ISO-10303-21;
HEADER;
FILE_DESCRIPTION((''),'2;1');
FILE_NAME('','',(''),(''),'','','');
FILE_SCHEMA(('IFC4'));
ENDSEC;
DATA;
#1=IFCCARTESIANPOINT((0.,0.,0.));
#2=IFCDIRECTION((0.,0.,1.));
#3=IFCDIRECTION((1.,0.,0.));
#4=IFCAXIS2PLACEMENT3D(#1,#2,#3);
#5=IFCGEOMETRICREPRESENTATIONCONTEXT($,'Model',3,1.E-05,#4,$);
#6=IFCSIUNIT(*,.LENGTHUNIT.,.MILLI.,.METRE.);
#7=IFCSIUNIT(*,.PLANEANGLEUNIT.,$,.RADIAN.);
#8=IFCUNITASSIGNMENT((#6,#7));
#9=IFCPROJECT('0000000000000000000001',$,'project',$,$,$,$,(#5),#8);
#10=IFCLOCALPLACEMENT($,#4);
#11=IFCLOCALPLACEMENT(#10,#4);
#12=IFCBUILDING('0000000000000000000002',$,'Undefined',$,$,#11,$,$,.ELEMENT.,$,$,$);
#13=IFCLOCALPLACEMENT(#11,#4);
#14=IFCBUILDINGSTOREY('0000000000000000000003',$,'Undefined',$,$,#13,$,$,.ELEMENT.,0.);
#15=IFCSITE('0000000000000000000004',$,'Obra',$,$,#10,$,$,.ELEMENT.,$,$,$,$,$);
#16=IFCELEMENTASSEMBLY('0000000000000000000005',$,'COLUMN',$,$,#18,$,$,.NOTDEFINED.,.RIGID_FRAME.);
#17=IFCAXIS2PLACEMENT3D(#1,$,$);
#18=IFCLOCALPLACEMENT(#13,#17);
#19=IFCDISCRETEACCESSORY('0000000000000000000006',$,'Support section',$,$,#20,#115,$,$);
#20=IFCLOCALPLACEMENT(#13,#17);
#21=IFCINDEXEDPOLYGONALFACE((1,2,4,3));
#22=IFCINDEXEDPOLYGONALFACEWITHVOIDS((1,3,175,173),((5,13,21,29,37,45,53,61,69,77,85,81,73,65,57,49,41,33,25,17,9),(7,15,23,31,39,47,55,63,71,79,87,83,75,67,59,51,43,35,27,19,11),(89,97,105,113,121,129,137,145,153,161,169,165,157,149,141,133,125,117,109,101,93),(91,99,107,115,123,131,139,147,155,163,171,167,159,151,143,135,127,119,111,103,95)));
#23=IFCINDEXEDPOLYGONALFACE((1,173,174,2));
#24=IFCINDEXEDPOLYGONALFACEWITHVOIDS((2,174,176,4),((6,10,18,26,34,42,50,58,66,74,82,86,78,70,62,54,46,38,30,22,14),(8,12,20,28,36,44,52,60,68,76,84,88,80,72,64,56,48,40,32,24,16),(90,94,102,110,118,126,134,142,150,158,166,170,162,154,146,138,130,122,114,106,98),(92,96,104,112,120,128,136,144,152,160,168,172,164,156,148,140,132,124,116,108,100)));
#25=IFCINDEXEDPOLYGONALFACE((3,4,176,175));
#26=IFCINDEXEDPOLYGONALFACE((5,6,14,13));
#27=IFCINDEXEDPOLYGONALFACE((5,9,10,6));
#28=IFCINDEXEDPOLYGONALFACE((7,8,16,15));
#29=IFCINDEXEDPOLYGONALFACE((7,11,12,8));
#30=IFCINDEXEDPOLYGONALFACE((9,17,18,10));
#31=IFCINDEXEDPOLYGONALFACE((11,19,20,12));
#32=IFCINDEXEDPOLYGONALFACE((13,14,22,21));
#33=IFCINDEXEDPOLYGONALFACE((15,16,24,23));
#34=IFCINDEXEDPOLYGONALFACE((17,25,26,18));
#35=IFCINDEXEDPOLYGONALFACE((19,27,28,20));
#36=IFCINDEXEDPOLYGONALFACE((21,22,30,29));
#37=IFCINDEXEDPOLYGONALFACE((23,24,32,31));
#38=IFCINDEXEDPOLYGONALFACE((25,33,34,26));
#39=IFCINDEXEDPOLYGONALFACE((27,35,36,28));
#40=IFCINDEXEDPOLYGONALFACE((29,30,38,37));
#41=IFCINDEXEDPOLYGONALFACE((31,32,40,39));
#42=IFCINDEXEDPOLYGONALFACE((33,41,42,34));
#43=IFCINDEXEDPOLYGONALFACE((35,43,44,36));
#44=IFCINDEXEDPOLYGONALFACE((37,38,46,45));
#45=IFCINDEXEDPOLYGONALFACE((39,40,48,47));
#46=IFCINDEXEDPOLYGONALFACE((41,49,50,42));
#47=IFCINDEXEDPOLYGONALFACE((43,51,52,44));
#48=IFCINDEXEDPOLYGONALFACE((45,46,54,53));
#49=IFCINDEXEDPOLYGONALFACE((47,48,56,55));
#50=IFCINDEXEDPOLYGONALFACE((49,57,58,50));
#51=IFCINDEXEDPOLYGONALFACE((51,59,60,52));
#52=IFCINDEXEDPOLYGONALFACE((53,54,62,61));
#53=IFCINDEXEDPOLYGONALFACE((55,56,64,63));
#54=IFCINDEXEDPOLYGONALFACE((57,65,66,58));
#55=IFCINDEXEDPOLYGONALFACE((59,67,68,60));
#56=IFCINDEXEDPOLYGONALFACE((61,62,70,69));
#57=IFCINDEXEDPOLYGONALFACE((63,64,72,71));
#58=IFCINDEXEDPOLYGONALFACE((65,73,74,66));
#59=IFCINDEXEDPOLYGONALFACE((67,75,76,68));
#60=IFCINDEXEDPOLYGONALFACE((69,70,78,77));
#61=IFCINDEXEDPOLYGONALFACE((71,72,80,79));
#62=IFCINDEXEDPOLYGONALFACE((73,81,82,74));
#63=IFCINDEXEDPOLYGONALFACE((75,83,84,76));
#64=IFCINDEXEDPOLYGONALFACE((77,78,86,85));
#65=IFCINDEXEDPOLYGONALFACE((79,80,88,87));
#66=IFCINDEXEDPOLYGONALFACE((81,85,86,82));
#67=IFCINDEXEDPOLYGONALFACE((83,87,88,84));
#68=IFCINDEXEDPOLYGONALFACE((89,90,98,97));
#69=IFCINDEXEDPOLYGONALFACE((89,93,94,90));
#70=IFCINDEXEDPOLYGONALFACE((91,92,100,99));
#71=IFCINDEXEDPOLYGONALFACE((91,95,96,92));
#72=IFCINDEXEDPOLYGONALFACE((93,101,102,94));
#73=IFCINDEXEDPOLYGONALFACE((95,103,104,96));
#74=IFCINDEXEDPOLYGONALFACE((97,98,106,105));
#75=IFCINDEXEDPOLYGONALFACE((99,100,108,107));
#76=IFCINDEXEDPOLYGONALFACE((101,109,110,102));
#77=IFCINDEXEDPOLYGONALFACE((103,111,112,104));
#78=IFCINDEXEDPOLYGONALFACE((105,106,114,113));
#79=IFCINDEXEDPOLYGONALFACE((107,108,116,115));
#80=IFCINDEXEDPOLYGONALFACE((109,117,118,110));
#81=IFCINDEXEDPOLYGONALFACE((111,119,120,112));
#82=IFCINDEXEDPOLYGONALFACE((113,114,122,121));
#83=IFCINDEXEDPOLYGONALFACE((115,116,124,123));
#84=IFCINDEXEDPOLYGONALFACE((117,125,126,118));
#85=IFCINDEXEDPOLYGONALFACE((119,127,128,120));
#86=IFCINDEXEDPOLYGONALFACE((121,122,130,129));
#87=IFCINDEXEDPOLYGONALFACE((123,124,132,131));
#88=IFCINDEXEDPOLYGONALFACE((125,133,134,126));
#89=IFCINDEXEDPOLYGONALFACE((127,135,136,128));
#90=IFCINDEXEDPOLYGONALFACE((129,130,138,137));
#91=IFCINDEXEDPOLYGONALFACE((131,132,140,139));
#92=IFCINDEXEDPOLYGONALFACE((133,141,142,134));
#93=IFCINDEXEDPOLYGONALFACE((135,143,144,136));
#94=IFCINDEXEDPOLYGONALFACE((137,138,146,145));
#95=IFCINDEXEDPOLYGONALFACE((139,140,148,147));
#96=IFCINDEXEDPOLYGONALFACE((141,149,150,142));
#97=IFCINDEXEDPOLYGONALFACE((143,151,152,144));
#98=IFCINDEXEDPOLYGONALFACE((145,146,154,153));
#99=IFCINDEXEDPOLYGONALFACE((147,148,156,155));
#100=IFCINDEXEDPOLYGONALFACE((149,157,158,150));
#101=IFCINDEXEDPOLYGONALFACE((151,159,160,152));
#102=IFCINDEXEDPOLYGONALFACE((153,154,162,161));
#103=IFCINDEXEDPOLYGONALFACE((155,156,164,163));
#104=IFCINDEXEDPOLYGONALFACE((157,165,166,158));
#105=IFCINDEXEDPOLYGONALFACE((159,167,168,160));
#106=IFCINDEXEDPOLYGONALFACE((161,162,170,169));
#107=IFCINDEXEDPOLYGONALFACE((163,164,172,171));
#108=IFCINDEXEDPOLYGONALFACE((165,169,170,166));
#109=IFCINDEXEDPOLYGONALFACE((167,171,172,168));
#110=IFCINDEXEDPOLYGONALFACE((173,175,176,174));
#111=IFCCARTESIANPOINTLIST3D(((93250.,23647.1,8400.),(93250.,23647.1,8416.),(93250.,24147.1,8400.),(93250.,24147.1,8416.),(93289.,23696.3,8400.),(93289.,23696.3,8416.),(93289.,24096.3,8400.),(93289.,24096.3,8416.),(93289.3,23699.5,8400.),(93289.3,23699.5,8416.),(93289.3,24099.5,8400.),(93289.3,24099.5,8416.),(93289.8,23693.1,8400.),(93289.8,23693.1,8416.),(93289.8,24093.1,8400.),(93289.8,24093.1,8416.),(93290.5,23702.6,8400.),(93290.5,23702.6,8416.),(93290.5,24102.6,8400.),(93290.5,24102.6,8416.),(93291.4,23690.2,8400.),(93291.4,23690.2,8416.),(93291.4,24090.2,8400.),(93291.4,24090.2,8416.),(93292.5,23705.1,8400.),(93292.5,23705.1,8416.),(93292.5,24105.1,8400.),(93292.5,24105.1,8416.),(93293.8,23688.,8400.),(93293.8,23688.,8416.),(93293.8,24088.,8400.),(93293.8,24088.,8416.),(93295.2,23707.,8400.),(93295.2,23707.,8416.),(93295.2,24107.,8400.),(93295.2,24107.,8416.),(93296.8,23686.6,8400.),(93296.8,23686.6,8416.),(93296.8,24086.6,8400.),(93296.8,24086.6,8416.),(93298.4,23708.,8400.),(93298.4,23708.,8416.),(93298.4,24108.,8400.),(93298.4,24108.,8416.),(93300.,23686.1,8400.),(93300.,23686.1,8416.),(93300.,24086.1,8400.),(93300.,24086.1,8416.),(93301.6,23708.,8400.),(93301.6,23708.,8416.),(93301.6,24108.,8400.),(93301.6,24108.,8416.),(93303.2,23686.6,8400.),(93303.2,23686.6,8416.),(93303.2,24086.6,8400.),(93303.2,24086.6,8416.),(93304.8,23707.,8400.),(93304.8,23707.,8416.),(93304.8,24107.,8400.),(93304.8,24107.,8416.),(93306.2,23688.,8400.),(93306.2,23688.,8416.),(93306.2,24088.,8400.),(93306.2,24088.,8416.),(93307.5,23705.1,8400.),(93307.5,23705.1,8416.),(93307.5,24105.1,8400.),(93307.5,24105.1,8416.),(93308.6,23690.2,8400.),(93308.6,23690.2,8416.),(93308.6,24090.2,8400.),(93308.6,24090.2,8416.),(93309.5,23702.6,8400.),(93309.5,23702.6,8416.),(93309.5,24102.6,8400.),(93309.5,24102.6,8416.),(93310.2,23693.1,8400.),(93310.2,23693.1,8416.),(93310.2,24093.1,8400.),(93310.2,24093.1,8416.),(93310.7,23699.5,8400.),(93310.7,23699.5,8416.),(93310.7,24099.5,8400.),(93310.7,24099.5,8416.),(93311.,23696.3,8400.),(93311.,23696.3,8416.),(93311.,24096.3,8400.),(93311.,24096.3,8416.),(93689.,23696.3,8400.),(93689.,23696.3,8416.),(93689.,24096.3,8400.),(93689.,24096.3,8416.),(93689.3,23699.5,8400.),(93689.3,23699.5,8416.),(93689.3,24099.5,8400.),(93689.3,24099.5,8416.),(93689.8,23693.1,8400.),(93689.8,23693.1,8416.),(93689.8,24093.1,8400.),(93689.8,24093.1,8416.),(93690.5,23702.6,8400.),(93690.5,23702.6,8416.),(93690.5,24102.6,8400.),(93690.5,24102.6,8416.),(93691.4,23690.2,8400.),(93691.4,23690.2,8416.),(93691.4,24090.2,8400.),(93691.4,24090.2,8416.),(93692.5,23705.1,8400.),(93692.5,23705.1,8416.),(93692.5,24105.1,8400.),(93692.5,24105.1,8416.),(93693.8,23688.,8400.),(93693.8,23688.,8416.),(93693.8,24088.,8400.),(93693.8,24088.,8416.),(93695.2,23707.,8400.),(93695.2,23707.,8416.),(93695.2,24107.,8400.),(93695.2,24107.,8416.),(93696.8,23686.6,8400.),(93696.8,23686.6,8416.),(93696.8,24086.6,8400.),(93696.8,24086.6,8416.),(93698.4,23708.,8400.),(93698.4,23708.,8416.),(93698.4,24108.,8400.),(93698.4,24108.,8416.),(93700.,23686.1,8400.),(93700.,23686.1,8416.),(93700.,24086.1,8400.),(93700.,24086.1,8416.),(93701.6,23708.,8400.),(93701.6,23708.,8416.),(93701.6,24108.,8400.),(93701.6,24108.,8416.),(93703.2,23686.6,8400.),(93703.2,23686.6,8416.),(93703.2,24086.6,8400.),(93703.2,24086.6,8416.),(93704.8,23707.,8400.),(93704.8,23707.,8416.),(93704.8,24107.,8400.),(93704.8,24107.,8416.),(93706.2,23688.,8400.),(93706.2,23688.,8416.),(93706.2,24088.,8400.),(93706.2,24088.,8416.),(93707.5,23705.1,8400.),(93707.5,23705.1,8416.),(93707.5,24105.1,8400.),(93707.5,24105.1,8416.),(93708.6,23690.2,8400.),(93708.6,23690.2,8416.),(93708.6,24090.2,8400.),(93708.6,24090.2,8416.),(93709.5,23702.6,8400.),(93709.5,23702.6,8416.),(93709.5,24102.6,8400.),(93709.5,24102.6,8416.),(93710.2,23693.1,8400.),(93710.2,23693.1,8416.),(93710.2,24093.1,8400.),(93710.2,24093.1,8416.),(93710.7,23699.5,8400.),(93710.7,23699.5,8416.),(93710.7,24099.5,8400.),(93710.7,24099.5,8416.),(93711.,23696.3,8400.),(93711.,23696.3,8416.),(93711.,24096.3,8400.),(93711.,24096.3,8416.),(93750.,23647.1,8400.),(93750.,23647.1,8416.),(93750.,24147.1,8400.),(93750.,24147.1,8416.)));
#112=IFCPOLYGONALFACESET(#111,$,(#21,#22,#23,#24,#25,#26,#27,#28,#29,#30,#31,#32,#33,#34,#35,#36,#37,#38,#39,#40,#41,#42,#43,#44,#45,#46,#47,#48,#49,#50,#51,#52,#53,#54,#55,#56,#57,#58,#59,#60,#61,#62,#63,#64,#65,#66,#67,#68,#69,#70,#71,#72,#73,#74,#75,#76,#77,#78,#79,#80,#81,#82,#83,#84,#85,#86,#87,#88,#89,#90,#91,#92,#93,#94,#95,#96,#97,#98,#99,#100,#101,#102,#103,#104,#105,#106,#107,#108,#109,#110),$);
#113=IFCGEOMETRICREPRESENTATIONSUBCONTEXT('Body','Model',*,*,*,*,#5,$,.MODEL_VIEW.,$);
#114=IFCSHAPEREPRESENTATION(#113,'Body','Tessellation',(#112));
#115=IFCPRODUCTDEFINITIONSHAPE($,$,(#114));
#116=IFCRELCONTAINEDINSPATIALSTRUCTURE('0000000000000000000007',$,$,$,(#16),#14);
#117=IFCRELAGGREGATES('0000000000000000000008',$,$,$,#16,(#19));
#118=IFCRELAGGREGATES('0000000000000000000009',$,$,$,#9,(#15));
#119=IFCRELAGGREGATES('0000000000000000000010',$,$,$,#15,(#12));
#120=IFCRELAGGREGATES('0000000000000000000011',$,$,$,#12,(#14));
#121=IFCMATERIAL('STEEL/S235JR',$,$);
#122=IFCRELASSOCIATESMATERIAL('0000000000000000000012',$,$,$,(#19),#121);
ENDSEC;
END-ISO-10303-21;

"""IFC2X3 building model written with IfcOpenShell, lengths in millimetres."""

from ifc_helpers import new_model, si_unit, frame, origin_with_axes, origin_2d_with_axis, place, context, subcontext, project, spatial, rectangle, circle, extrude, source, transform, mapped, material, element, aggregate, save


model = new_model("IFC2X3")

# Units and contexts
model_context = context("Model", 3, precision=1e-05, world=origin_with_axes())
body_context = subcontext(model_context, "Body", "Model", "MODEL_VIEW")
ifc_project = project(units=[si_unit("LENGTHUNIT", "METRE", prefix="MILLI"), si_unit("PLANEANGLEUNIT", "RADIAN")], contexts=[model_context])

# Site, building, storey
site_placement = place(None, origin_with_axes())
site = spatial("IfcSite", under=ifc_project, at=site_placement, Name="Obra", CompositionType="ELEMENT")
building_placement = place(site_placement, origin_with_axes())
building = spatial("IfcBuilding", under=site, at=building_placement, Name="Undefined", CompositionType="ELEMENT")
storey_placement = place(building_placement, origin_with_axes())
storey = spatial("IfcBuildingStorey", under=building, at=storey_placement, Name="Undefined", CompositionType="ELEMENT", Elevation=0.0)

# Shared definitions
ifc_material_1 = material(Name="STEEL/S235JR")

# Element assembly, discrete accessory, opening
assembly_1_placement = place(storey_placement, origin_with_axes())
assembly_1 = element("IfcElementAssembly", 1, at=assembly_1_placement, inside=storey, Name="COLUMN", AssemblyPlace="NOTDEFINED", PredefinedType="RIGID_FRAME")
discrete_accessory_1_placement = place(assembly_1_placement, frame((93500.0, 23647.1, 8408.0), z_axis=(-1.0, 0.0, 0.0), x_axis=(0.0, 1.0, 0.0)))
discrete_accessory_1 = element("IfcDiscreteAccessory", 2, at=discrete_accessory_1_placement, material=ifc_material_1, Name="Support section", context=body_context, shape_type="SweptSolid", body=[
    extrude(rectangle(XDim=16.0, YDim=500.0, at=origin_2d_with_axis()), frame((500.0, 0.0, 0.0), z_axis=(-1.0, 0.0, 0.0), x_axis=(0.0, -1.0, 0.0)), (0.0, 0.0, 1.0), 500.0),
])
shared_shape_1 = source(origin_with_axes(), body_context, "Body", "SweptSolid", [
    extrude(circle(Radius=11.0, at=origin_2d_with_axis()), frame((0.0, -0.1, 0.0), z_axis=(0.0, 1.0, 0.0), x_axis=(1.0, 0.0, 0.0)), (0.0, 0.0, 1.0), 16.2),
])
opening_1_placement = place(assembly_1_placement, frame((93500.0, 24100.1, 8416.0), z_axis=(1.0, 0.0, 0.0), x_axis=(0.0, -1.0, 0.0)))
element("IfcOpeningElement", 3, at=opening_1_placement, cuts=discrete_accessory_1, ObjectType="Opening", context=body_context, shape_type="MappedRepresentation", body=[
    mapped(shared_shape_1, transform((3.0, 0.0, 200.0))),
    mapped(shared_shape_1, transform((3.0, 0.0, -200.0))),
    mapped(shared_shape_1, transform((403.0, 0.0, 200.0))),
    mapped(shared_shape_1, transform((403.0, 0.0, -200.0))),
])
aggregate(assembly_1, [discrete_accessory_1])

save(model, "model.ifc")
